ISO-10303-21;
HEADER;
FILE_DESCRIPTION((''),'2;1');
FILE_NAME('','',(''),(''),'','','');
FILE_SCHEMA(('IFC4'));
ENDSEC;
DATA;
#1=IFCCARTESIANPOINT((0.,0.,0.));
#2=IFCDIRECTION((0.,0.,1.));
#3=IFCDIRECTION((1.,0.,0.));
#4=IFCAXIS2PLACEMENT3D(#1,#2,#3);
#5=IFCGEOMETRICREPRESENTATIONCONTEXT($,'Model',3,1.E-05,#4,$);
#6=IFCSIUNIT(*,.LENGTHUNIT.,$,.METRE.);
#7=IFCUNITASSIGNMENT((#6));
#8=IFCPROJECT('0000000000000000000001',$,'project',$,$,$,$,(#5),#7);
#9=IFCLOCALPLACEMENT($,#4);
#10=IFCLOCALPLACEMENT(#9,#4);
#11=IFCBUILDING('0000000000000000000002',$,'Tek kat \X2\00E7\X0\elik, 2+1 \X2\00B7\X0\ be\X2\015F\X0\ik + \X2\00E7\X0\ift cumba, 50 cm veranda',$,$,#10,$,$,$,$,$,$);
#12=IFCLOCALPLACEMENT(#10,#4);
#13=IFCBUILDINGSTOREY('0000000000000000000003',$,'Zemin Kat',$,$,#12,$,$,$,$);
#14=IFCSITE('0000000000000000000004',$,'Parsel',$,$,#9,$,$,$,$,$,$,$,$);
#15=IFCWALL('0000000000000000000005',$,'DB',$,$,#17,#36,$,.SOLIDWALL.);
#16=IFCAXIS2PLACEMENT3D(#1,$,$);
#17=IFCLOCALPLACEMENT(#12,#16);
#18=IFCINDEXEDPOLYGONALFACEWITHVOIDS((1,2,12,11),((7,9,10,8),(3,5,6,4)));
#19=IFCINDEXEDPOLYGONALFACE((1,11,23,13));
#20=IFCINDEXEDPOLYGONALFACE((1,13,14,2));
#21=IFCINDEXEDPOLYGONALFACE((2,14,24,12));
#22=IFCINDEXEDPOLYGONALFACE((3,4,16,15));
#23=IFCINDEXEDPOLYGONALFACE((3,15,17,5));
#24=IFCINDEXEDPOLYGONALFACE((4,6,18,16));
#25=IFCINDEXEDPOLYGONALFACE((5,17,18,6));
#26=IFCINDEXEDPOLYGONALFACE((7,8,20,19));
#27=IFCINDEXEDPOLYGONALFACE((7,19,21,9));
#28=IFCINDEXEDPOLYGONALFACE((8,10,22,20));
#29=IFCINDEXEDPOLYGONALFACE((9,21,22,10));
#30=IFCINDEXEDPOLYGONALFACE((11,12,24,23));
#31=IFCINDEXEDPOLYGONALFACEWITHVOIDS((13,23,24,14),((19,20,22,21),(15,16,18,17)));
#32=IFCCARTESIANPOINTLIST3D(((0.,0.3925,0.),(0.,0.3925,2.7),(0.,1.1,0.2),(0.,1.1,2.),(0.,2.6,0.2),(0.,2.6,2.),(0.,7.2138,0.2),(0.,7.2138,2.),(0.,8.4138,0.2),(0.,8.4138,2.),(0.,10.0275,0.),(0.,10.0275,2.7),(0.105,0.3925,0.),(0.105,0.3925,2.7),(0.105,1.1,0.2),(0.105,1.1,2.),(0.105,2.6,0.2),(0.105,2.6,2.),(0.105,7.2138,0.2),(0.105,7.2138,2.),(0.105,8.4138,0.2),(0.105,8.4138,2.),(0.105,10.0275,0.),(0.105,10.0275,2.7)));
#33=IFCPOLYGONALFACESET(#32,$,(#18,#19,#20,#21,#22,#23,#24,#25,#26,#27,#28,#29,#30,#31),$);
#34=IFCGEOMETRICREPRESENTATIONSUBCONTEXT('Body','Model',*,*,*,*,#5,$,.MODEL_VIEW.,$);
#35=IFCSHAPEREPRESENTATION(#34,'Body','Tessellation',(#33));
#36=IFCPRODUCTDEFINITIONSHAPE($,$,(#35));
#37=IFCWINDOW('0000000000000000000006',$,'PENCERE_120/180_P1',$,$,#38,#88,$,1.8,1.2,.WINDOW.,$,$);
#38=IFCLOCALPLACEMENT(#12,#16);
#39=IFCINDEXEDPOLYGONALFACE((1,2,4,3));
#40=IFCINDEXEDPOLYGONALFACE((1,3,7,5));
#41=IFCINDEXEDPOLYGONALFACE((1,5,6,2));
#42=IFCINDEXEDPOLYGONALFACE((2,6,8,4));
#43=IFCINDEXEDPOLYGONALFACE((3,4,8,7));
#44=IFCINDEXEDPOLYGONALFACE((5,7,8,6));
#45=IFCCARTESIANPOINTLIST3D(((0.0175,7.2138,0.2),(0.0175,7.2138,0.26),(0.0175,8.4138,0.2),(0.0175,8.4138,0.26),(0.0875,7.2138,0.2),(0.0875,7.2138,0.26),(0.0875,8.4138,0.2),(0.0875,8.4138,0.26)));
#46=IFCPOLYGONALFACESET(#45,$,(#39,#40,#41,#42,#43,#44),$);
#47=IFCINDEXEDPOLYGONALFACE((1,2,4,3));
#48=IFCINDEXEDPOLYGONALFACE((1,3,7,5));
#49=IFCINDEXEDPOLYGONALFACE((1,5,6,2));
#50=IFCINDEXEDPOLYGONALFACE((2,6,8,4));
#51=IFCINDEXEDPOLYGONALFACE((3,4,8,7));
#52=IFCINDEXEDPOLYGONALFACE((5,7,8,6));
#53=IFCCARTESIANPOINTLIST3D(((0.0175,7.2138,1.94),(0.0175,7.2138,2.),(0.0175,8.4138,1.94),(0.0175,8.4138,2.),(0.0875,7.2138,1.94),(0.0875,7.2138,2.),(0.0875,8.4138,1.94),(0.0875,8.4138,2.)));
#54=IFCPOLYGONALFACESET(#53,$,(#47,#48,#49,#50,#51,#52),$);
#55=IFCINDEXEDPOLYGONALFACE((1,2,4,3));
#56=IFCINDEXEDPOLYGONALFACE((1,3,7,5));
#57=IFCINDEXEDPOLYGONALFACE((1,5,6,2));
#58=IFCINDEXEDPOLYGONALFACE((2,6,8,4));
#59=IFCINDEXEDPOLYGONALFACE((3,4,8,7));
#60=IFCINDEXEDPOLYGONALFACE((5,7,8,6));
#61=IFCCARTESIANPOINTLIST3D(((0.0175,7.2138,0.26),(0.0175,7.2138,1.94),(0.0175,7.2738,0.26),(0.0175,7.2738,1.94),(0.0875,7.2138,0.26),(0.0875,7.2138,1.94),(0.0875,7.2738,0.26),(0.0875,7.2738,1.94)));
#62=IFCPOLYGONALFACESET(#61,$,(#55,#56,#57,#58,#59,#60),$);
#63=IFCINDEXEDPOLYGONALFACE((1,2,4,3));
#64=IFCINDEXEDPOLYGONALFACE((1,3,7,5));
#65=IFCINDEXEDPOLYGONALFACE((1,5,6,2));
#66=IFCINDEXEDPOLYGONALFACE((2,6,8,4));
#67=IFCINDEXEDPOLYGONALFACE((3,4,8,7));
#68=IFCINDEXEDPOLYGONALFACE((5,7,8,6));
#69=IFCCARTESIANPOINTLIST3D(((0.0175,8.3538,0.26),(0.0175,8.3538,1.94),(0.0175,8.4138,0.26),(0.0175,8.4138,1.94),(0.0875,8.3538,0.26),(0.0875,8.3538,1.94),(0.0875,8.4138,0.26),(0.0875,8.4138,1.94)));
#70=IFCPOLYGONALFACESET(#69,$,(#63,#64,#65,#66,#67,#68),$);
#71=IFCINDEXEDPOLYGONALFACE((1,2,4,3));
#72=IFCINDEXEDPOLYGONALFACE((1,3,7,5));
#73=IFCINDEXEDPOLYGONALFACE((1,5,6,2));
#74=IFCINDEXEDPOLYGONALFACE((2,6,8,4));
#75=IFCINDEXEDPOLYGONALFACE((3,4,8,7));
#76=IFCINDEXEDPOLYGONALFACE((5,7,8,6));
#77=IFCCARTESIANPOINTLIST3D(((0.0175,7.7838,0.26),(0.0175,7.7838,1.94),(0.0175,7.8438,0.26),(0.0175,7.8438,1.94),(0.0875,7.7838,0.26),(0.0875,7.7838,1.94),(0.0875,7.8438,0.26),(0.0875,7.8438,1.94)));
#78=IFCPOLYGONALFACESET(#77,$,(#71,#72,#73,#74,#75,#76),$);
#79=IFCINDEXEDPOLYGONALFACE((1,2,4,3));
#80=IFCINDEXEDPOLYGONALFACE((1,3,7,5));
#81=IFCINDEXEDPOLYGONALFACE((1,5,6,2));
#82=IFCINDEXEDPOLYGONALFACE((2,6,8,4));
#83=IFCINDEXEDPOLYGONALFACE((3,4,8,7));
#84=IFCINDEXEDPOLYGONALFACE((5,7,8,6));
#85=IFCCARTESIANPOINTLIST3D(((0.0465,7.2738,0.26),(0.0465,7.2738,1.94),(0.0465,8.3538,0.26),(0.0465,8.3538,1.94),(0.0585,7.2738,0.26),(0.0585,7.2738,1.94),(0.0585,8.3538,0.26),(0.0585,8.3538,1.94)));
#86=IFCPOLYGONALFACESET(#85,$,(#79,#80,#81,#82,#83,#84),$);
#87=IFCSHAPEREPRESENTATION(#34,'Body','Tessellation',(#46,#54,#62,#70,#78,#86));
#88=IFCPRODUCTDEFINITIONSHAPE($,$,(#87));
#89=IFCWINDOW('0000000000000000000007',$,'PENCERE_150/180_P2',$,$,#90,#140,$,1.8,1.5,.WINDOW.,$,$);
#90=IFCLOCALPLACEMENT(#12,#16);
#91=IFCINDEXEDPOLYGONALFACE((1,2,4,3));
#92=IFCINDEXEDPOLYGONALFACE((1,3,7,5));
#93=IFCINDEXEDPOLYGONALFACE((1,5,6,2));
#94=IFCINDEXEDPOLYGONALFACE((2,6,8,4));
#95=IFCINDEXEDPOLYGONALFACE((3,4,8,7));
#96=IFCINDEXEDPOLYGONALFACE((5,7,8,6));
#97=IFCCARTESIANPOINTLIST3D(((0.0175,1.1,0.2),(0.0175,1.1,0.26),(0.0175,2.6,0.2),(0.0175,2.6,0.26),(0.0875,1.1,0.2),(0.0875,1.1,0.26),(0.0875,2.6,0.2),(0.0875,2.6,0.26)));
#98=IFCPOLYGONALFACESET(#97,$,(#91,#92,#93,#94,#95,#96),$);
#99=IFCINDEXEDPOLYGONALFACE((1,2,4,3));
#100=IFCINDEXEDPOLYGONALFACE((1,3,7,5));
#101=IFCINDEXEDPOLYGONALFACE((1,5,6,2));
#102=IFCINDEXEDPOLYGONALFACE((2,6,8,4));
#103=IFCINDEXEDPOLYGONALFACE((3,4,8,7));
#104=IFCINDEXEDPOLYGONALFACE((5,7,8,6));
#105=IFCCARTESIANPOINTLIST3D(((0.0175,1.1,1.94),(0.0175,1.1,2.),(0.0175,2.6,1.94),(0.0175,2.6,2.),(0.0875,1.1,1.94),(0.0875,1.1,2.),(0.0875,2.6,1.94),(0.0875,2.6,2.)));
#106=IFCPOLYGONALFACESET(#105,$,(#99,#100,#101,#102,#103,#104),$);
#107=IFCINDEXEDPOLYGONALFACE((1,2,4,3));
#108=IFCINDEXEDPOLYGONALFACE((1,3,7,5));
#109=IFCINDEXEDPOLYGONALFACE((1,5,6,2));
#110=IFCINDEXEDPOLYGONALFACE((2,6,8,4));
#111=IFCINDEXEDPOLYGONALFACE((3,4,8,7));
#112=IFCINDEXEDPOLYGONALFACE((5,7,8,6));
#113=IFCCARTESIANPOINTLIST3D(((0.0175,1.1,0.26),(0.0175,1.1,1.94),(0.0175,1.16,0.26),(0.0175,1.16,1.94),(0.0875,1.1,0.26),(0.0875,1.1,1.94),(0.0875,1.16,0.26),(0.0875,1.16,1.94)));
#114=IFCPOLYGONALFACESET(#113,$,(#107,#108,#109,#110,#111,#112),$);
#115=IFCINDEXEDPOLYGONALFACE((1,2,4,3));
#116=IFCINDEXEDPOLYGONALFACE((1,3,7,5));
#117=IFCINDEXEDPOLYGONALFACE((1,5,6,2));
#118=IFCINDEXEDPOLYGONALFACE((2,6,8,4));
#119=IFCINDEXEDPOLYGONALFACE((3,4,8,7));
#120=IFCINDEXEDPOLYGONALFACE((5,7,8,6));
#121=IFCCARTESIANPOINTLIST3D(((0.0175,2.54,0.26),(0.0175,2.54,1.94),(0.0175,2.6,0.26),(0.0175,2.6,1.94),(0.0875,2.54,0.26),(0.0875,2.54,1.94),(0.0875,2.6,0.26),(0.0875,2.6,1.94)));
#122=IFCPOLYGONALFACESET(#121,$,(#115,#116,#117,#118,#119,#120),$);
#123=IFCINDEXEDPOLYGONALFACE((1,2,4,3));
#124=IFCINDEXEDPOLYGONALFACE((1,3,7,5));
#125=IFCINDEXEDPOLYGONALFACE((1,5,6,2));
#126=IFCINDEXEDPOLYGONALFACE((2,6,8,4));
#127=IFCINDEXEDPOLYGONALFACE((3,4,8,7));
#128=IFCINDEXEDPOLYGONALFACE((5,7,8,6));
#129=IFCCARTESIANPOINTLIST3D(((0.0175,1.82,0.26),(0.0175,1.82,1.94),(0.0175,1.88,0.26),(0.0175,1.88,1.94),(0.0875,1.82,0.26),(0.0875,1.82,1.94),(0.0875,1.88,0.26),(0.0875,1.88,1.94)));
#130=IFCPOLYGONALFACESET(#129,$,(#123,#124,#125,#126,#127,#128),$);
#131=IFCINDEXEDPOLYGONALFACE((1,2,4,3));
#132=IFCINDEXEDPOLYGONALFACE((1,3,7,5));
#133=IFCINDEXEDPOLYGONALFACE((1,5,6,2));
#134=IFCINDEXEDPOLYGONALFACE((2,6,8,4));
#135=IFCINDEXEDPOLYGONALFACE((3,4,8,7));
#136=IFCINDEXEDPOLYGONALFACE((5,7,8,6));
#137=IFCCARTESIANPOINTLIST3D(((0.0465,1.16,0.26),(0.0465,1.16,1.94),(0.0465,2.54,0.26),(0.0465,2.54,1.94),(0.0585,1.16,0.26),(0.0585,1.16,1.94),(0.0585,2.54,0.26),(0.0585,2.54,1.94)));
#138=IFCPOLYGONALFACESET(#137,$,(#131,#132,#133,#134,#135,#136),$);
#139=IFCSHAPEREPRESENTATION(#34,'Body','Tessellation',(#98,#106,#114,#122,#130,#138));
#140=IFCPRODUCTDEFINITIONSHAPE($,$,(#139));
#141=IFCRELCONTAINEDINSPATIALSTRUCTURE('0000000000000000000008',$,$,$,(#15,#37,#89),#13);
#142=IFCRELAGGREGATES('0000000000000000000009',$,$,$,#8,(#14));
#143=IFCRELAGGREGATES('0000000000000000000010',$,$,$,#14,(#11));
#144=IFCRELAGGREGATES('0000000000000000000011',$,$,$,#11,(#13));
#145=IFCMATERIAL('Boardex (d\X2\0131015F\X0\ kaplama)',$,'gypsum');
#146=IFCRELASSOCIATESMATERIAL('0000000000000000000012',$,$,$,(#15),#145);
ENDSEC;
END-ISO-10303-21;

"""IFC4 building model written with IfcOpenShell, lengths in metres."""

from ifc_helpers import new_model, si_unit, frame, origin_with_axes, place, context, subcontext, project, spatial, line, indexed_curve, outline, extrude, material, element, fill, save


model = new_model("IFC4")

# Units and contexts
model_context = context("Model", 3, precision=1e-05, world=origin_with_axes())
body_context = subcontext(model_context, "Body", "Model", "MODEL_VIEW")
ifc_project = project(units=[si_unit("LENGTHUNIT", "METRE")], contexts=[model_context])

# Site, building, storey
site_placement = place(None, origin_with_axes())
site = spatial("IfcSite", under=ifc_project, at=site_placement, Name="Parsel")
building_placement = place(site_placement, origin_with_axes())
building = spatial("IfcBuilding", under=site, at=building_placement, Name="Tek kat çelik, 2+1 · beşik + çift cumba, 50 cm veranda")
storey_placement = place(building_placement, origin_with_axes())
storey = spatial("IfcBuildingStorey", under=building, at=storey_placement, Name="Zemin Kat")

# Shared definitions
ifc_material_1 = material(Name="Boardex (dış kaplama)", Category="gypsum")

# Wall, openings, windows
wall_1_placement = place(storey_placement, origin_with_axes())
wall_1 = element("IfcWall", 1, at=wall_1_placement, inside=storey, material=ifc_material_1, Name="DB", PredefinedType="SOLIDWALL", context=body_context, shape_type="SweptSolid", body=[
    extrude(outline(indexed_curve([(0.0, 0.0), (0.105, 0.0), (0.105, 9.635), (0.0, 9.635)], segments=[line(1, 2, 3, 4, 1)])), frame((0.0, 0.3925, 0.0), z_axis=(0.0, 0.0, 1.0), x_axis=(1.0, 0.0, 0.0)), (0.0, 0.0, 1.0), 2.7),
])
opening_1_placement = place(wall_1_placement, origin_with_axes())
opening_1 = element("IfcOpeningElement", 2, at=opening_1_placement, cuts=wall_1, PredefinedType="OPENING", context=body_context, shape_type="SweptSolid", body=[
    extrude(outline(indexed_curve([(0.0, 0.0), (0.145, 0.0), (0.145, 1.2), (0.0, 1.2)], segments=[line(1, 2, 3, 4, 1)])), frame((-0.02, 7.2138, 0.2), z_axis=(0.0, 0.0, 1.0), x_axis=(1.0, 0.0, 0.0)), (0.0, 0.0, 1.0), 1.8),
])
opening_2_placement = place(wall_1_placement, origin_with_axes())
opening_2 = element("IfcOpeningElement", 3, at=opening_2_placement, cuts=wall_1, PredefinedType="OPENING", context=body_context, shape_type="SweptSolid", body=[
    extrude(outline(indexed_curve([(0.0, 0.0), (0.145, 0.0), (0.145, 1.5), (0.0, 1.5)], segments=[line(1, 2, 3, 4, 1)])), frame((-0.02, 1.1, 0.2), z_axis=(0.0, 0.0, 1.0), x_axis=(1.0, 0.0, 0.0)), (0.0, 0.0, 1.0), 1.8),
])
window_1_placement = place(storey_placement, origin_with_axes())
window_1 = element("IfcWindow", 4, at=window_1_placement, inside=storey, Name="PENCERE_120/180_P1", OverallHeight=1.8, OverallWidth=1.2, PredefinedType="WINDOW", context=body_context, shape_type="SweptSolid", body=[
    extrude(outline(indexed_curve([(0.0, 0.0), (0.07, 0.0), (0.07, 1.2), (0.0, 1.2)], segments=[line(1, 2, 3, 4, 1)])), frame((0.0175, 7.2138, 0.2), z_axis=(0.0, 0.0, 1.0), x_axis=(1.0, 0.0, 0.0)), (0.0, 0.0, 1.0), 0.06),
    extrude(outline(indexed_curve([(0.0, 0.0), (0.07, 0.0), (0.07, 1.2), (0.0, 1.2)], segments=[line(1, 2, 3, 4, 1)])), frame((0.0175, 7.2138, 1.94), z_axis=(0.0, 0.0, 1.0), x_axis=(1.0, 0.0, 0.0)), (0.0, 0.0, 1.0), 0.06),
    extrude(outline(indexed_curve([(0.0, 0.0), (0.07, 0.0), (0.07, 0.06), (0.0, 0.06)], segments=[line(1, 2, 3, 4, 1)])), frame((0.0175, 7.2138, 0.26), z_axis=(0.0, 0.0, 1.0), x_axis=(1.0, 0.0, 0.0)), (0.0, 0.0, 1.0), 1.68),
    extrude(outline(indexed_curve([(0.0, 0.0), (0.07, 0.0), (0.07, 0.06), (0.0, 0.06)], segments=[line(1, 2, 3, 4, 1)])), frame((0.0175, 8.3538, 0.26), z_axis=(0.0, 0.0, 1.0), x_axis=(1.0, 0.0, 0.0)), (0.0, 0.0, 1.0), 1.68),
    extrude(outline(indexed_curve([(0.0, 0.0), (0.07, 0.0), (0.07, 0.06), (0.0, 0.06)], segments=[line(1, 2, 3, 4, 1)])), frame((0.0175, 7.7838, 0.26), z_axis=(0.0, 0.0, 1.0), x_axis=(1.0, 0.0, 0.0)), (0.0, 0.0, 1.0), 1.68),
    extrude(outline(indexed_curve([(0.0, 0.0), (0.012, 0.0), (0.012, 1.08), (0.0, 1.08)], segments=[line(1, 2, 3, 4, 1)])), frame((0.0465, 7.2738, 0.26), z_axis=(0.0, 0.0, 1.0), x_axis=(1.0, 0.0, 0.0)), (0.0, 0.0, 1.0), 1.68),
])
fill(opening_1, window_1)
window_2_placement = place(storey_placement, origin_with_axes())
window_2 = element("IfcWindow", 5, at=window_2_placement, inside=storey, Name="PENCERE_150/180_P2", OverallHeight=1.8, OverallWidth=1.5, PredefinedType="WINDOW", context=body_context, shape_type="SweptSolid", body=[
    extrude(outline(indexed_curve([(0.0, 0.0), (0.07, 0.0), (0.07, 1.5), (0.0, 1.5)], segments=[line(1, 2, 3, 4, 1)])), frame((0.0175, 1.1, 0.2), z_axis=(0.0, 0.0, 1.0), x_axis=(1.0, 0.0, 0.0)), (0.0, 0.0, 1.0), 0.06),
    extrude(outline(indexed_curve([(0.0, 0.0), (0.07, 0.0), (0.07, 1.5), (0.0, 1.5)], segments=[line(1, 2, 3, 4, 1)])), frame((0.0175, 1.1, 1.94), z_axis=(0.0, 0.0, 1.0), x_axis=(1.0, 0.0, 0.0)), (0.0, 0.0, 1.0), 0.06),
    extrude(outline(indexed_curve([(0.0, 0.0), (0.07, 0.0), (0.07, 0.06), (0.0, 0.06)], segments=[line(1, 2, 3, 4, 1)])), frame((0.0175, 1.1, 0.26), z_axis=(0.0, 0.0, 1.0), x_axis=(1.0, 0.0, 0.0)), (0.0, 0.0, 1.0), 1.68),
    extrude(outline(indexed_curve([(0.0, 0.0), (0.07, 0.0), (0.07, 0.06), (0.0, 0.06)], segments=[line(1, 2, 3, 4, 1)])), frame((0.0175, 2.54, 0.26), z_axis=(0.0, 0.0, 1.0), x_axis=(1.0, 0.0, 0.0)), (0.0, 0.0, 1.0), 1.68),
    extrude(outline(indexed_curve([(0.0, 0.0), (0.07, 0.0), (0.07, 0.06), (0.0, 0.06)], segments=[line(1, 2, 3, 4, 1)])), frame((0.0175, 1.82, 0.26), z_axis=(0.0, 0.0, 1.0), x_axis=(1.0, 0.0, 0.0)), (0.0, 0.0, 1.0), 1.68),
    extrude(outline(indexed_curve([(0.0, 0.0), (0.012, 0.0), (0.012, 1.38), (0.0, 1.38)], segments=[line(1, 2, 3, 4, 1)])), frame((0.0465, 1.16, 0.26), z_axis=(0.0, 0.0, 1.0), x_axis=(1.0, 0.0, 0.0)), (0.0, 0.0, 1.0), 1.68),
])
fill(opening_2, window_2)

save(model, "model.ifc")
